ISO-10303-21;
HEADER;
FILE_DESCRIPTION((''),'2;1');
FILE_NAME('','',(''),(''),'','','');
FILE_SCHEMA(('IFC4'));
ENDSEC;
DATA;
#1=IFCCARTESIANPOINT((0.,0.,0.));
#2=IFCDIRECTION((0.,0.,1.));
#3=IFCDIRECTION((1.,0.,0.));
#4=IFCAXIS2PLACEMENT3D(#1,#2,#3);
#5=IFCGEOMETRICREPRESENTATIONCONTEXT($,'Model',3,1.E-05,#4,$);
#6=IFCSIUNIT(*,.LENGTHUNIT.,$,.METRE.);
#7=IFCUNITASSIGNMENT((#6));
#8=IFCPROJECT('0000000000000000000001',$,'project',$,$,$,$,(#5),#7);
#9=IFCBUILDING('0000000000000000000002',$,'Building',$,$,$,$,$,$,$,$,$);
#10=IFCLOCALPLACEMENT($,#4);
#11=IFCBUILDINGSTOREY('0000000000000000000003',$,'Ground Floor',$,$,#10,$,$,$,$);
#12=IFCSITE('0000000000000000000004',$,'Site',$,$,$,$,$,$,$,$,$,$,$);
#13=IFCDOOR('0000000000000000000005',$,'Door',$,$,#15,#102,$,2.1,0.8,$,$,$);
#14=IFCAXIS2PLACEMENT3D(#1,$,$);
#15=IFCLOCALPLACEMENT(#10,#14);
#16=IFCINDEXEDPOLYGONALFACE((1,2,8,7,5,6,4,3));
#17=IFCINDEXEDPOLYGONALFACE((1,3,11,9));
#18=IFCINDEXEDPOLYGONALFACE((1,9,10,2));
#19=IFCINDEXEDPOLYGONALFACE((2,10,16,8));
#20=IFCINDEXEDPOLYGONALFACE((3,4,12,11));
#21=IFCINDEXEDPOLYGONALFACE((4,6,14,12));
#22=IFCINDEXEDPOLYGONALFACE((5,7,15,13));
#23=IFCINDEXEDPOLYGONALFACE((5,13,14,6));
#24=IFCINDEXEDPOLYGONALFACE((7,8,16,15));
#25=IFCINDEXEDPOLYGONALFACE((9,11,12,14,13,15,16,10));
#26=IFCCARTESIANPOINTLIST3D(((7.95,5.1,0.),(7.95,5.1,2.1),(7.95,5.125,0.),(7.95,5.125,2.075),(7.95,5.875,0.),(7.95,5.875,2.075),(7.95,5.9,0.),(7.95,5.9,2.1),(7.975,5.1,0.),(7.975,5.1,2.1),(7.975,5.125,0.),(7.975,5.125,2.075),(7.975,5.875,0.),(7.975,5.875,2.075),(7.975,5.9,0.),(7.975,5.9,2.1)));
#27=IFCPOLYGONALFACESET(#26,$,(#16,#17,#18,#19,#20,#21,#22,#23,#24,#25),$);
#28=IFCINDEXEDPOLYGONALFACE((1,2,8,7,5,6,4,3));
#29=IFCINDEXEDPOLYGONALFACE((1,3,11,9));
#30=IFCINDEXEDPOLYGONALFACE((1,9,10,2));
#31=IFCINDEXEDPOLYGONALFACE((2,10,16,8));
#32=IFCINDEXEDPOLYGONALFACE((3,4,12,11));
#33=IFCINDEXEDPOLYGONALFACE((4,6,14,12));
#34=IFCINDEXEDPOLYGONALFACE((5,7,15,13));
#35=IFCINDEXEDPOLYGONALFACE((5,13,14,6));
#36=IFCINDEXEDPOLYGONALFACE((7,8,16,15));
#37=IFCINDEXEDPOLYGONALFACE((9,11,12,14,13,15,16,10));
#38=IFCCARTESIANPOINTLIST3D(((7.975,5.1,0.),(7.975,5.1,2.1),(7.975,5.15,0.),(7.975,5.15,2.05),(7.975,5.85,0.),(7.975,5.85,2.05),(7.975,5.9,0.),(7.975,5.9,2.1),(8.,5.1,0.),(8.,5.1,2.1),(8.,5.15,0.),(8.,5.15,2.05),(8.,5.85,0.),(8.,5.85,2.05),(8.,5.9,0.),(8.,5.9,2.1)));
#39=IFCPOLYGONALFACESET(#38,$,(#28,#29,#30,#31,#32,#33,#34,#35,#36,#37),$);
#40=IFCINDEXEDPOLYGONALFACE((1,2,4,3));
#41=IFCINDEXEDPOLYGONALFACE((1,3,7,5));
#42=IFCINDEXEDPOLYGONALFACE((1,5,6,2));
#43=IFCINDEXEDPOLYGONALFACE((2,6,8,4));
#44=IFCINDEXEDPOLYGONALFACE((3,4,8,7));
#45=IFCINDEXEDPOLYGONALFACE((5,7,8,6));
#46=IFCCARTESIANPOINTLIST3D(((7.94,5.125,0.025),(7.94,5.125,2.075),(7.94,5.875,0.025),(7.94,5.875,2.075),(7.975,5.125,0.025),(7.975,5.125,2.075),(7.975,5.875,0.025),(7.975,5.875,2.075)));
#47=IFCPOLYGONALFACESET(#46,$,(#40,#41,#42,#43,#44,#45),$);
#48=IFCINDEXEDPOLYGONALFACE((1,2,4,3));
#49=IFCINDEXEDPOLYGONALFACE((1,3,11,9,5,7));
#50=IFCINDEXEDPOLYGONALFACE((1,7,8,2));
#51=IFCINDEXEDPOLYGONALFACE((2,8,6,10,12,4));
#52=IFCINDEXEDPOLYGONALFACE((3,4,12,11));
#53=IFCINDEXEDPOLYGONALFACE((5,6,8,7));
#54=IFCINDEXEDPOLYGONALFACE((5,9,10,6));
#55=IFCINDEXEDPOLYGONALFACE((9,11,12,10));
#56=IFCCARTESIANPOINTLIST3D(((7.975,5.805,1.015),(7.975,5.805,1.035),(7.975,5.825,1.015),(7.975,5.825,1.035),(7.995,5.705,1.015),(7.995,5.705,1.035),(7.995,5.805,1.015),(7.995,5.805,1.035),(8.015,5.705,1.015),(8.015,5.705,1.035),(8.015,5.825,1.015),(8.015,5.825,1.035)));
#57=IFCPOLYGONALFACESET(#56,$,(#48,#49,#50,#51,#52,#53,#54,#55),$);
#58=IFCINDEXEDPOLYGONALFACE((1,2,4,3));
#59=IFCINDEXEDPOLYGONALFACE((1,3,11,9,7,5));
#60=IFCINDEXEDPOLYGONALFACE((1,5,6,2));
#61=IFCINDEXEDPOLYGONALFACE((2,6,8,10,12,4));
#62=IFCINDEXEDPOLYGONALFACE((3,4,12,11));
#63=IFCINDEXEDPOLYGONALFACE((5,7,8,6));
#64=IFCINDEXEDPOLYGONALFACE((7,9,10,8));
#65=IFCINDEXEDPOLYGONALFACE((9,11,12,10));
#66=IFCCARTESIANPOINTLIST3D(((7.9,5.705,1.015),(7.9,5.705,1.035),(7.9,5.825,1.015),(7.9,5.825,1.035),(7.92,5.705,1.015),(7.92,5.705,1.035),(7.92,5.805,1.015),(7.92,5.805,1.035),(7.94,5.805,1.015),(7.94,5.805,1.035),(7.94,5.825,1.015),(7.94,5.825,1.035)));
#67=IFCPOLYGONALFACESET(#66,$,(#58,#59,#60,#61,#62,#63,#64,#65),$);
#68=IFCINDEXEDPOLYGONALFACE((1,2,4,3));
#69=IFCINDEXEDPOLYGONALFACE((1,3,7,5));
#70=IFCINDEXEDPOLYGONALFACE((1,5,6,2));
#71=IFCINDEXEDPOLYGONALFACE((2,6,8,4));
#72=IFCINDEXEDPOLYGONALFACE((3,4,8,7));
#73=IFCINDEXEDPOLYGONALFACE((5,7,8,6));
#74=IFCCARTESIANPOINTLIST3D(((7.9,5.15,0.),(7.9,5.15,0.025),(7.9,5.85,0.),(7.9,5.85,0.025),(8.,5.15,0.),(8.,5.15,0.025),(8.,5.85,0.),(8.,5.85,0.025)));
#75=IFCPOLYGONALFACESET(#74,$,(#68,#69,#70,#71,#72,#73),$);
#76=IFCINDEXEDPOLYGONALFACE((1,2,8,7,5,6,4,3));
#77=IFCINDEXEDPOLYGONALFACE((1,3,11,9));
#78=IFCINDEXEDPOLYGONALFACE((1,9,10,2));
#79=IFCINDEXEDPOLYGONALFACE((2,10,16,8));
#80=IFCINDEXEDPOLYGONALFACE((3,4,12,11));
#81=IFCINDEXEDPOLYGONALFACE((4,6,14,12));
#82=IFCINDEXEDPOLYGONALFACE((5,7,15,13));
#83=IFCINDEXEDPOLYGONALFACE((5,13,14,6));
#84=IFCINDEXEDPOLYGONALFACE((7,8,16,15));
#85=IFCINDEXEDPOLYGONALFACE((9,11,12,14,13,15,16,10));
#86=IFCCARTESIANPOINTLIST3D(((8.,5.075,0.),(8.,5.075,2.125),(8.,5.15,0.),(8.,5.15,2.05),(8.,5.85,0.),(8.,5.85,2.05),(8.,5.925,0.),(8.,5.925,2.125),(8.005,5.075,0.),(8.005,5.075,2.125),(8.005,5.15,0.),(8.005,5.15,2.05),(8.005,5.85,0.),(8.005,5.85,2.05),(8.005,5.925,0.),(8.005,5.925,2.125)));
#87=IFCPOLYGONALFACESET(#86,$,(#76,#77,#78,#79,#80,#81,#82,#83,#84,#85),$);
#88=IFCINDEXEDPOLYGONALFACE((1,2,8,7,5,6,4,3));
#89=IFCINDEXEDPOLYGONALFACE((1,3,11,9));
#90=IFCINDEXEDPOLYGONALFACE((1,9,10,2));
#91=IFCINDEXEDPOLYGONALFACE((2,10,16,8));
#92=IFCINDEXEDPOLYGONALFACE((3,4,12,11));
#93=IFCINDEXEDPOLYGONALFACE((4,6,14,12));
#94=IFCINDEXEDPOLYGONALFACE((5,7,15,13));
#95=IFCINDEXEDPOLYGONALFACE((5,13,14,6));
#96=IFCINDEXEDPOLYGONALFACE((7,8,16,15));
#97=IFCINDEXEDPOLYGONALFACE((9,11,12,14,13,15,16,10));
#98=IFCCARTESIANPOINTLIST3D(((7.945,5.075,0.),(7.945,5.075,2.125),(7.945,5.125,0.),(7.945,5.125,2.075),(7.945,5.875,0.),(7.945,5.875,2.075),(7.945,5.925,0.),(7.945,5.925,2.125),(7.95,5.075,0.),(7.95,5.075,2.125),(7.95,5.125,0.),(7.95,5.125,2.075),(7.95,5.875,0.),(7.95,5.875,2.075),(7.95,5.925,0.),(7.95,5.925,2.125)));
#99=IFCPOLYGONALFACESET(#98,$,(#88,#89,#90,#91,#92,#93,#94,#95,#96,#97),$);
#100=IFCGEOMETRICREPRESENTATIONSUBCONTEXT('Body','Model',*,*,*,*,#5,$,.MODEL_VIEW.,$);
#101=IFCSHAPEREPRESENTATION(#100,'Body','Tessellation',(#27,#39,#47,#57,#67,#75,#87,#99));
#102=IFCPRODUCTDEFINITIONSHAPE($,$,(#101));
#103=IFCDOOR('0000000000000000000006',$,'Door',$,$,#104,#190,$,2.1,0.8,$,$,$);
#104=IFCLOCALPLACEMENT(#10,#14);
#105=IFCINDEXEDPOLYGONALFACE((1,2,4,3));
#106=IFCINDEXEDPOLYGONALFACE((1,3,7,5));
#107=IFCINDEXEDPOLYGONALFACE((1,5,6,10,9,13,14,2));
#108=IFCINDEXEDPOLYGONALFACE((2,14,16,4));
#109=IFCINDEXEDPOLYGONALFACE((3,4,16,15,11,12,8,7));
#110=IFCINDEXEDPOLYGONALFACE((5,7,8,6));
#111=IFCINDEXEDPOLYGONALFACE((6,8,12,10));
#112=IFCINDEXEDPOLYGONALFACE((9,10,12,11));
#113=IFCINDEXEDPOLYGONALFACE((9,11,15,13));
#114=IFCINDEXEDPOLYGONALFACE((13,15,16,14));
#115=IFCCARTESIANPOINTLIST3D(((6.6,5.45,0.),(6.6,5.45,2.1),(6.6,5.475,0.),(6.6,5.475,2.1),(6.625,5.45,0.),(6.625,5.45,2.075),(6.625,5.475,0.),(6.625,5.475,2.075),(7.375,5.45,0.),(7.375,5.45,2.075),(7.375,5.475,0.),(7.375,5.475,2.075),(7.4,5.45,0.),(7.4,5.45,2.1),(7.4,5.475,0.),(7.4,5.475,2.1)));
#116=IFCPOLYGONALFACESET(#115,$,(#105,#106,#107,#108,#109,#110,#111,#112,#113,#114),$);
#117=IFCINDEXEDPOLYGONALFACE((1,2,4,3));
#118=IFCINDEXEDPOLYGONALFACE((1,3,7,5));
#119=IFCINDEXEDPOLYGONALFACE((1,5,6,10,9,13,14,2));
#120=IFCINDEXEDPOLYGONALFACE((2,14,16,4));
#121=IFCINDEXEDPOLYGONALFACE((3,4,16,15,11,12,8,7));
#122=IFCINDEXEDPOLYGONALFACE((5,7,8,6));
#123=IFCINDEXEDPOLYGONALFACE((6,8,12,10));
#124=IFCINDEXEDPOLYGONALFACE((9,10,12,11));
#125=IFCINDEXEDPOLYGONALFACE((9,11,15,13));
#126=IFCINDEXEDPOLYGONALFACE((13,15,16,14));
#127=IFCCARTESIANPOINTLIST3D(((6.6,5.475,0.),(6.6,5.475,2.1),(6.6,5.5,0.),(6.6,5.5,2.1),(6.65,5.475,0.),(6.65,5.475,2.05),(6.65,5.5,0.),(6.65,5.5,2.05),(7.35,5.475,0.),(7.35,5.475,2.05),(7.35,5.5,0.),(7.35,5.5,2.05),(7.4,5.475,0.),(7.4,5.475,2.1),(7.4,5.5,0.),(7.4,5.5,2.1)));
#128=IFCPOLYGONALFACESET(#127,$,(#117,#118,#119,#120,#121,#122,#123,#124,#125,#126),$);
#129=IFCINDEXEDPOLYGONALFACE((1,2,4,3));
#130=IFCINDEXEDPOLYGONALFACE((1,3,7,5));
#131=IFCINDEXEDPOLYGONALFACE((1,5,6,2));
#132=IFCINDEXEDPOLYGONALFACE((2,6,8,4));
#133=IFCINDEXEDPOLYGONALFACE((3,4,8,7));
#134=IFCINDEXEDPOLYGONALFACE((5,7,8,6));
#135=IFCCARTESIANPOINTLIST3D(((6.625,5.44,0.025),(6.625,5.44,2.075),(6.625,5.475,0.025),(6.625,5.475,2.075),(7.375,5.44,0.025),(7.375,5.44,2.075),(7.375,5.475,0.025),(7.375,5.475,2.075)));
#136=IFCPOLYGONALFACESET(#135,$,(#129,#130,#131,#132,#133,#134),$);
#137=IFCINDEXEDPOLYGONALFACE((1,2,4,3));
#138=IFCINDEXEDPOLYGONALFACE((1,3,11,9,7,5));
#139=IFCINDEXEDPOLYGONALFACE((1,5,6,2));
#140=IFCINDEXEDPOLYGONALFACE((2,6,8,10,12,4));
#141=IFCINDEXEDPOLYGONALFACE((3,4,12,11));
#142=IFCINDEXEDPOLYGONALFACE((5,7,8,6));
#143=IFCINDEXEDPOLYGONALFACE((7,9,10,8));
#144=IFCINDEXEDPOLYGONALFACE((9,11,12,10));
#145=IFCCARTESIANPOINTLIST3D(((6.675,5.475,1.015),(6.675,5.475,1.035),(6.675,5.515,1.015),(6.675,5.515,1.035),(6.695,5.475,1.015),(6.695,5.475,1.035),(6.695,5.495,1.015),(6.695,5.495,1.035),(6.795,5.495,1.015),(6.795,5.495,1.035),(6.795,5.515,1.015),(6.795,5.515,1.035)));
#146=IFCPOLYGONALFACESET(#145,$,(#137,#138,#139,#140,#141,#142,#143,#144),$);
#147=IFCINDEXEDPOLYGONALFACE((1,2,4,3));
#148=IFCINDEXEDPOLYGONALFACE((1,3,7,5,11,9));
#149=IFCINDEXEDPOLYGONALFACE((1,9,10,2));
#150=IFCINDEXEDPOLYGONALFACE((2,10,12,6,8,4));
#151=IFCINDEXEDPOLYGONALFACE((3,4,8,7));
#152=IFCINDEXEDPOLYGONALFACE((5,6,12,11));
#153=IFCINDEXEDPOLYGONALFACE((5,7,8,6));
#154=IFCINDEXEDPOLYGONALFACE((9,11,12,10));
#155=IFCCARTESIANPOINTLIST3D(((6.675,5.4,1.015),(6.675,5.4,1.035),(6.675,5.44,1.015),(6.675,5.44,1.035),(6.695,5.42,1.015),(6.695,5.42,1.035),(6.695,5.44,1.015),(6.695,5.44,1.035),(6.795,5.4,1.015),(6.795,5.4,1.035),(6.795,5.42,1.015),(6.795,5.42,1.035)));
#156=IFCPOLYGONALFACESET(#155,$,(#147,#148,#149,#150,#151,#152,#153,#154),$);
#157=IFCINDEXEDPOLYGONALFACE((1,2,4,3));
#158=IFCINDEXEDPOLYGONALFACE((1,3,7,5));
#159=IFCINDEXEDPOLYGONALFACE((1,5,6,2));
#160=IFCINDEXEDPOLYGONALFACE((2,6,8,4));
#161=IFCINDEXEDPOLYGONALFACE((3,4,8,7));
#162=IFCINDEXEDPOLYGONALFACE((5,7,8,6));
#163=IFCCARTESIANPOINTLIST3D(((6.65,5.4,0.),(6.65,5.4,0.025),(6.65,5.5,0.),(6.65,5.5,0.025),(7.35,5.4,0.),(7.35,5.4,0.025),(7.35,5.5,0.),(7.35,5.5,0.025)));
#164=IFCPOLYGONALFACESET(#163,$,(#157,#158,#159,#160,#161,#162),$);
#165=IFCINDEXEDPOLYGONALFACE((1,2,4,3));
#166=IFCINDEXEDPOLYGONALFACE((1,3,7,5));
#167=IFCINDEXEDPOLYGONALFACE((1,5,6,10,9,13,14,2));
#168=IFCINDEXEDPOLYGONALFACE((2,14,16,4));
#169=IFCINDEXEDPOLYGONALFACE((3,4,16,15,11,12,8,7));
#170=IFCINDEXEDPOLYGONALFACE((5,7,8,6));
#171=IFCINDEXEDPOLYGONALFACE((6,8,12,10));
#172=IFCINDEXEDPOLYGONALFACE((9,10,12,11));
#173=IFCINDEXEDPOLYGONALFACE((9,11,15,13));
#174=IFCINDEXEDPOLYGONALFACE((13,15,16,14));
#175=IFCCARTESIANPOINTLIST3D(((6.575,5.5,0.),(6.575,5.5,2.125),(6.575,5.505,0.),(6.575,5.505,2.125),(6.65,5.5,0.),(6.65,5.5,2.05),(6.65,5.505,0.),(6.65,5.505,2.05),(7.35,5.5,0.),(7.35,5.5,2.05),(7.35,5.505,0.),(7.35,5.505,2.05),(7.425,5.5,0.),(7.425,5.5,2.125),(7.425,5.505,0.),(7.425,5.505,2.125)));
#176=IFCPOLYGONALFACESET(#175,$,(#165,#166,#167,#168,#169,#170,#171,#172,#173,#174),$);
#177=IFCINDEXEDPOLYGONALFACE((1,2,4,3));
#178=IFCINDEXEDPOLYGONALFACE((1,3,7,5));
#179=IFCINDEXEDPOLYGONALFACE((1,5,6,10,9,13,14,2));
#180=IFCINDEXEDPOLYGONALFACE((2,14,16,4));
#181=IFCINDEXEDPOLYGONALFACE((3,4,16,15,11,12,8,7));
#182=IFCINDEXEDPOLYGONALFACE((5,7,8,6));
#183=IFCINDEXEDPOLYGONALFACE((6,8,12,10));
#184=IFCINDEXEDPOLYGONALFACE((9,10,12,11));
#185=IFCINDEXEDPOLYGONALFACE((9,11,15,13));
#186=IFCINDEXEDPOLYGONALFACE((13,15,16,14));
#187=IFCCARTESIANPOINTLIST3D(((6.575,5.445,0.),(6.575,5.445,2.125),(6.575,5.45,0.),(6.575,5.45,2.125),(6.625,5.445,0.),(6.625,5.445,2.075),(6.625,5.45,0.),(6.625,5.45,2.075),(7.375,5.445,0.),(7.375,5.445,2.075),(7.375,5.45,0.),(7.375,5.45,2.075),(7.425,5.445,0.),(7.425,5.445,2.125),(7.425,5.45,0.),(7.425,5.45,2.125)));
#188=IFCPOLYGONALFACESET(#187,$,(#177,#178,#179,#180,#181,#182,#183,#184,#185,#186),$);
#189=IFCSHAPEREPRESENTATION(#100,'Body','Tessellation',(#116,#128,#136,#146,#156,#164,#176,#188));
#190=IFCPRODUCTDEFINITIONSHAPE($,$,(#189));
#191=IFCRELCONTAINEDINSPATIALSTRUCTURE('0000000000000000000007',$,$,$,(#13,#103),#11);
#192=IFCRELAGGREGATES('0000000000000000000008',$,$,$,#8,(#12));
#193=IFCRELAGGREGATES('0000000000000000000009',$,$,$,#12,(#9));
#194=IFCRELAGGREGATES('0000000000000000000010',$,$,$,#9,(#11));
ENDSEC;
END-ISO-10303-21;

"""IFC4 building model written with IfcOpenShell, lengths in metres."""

from ifc_helpers import new_model, si_unit, frame, origin_with_axes, place, context, subcontext, project, spatial, line, indexed_curve, outline, extrude, element, save


model = new_model("IFC4")

# Units and contexts
model_context = context("Model", 3, precision=1e-05, world=origin_with_axes())
body_context = subcontext(model_context, "Body", "Model", "MODEL_VIEW")
ifc_project = project(units=[si_unit("LENGTHUNIT", "METRE")], contexts=[model_context])

# Site, building, storey
site = spatial("IfcSite", under=ifc_project, Name="Site")
building = spatial("IfcBuilding", under=site, Name="Building")
storey_placement = place(None, origin_with_axes())
storey = spatial("IfcBuildingStorey", under=building, at=storey_placement, Name="Ground Floor")

# Doors
door_1_placement = place(storey_placement, frame((8.0, 5.1, 0.0), z_axis=(0.0, 0.0, 1.0), x_axis=(0.0, 1.0, 0.0)))
element("IfcDoor", 1, at=door_1_placement, inside=storey, Name="Door", OverallHeight=2.1, OverallWidth=0.8, context=body_context, shape_type="SweptSolid", body=[
    extrude(outline(indexed_curve([(0.0, 0.0), (0.0, 2.1), (0.8, 2.1), (0.8, 0.0), (0.775, 0.0), (0.775, 2.075), (0.025, 2.075), (0.025, 0.0)], segments=[line(1, 2, 3, 4, 5, 6, 7, 8, 1)])), frame((0.0, 0.025, 0.0), z_axis=(0.0, -1.0, 0.0), x_axis=(1.0, 0.0, 0.0)), (0.0, 0.0, -1.0), 0.025),
    extrude(outline(indexed_curve([(0.0, 0.0), (0.0, 2.1), (0.8, 2.1), (0.8, 0.0), (0.75, 0.0), (0.75, 2.05), (0.05, 2.05), (0.05, 0.0)], segments=[line(1, 2, 3, 4, 5, 6, 7, 8, 1)])), frame((0.0, 0.0, 0.0), z_axis=(0.0, -1.0, 0.0), x_axis=(1.0, 0.0, 0.0)), (0.0, 0.0, -1.0), 0.025),
    extrude(outline(indexed_curve([(0.0, 0.0), (0.75, 0.0), (0.75, 0.035), (0.0, 0.035)], segments=[line(1, 2, 3, 4, 1)])), frame((0.025, 0.025, 0.025), z_axis=(0.0, 0.0, 1.0), x_axis=(1.0, 0.0, 0.0)), (0.0, 0.0, 1.0), 2.05),
    extrude(outline(indexed_curve([(0.0, 0.0), (0.0, -0.04), (-0.12, -0.04), (-0.12, -0.02), (-0.02, -0.02), (-0.02, 0.0)], segments=[line(1, 2, 3, 4, 5, 6, 1)])), frame((0.725, 0.025, 1.015), z_axis=(0.0, 0.0, 1.0), x_axis=(1.0, 0.0, 0.0)), (0.0, 0.0, 1.0), 0.02),
    extrude(outline(indexed_curve([(0.0, 0.0), (0.0, 0.04), (-0.12, 0.04), (-0.12, 0.02), (-0.02, 0.02), (-0.02, 0.0)], segments=[line(1, 2, 3, 4, 5, 6, 1)])), frame((0.725, 0.06, 1.015), z_axis=(0.0, 0.0, 1.0), x_axis=(1.0, 0.0, 0.0)), (0.0, 0.0, 1.0), 0.02),
    extrude(outline(indexed_curve([(0.0, 0.0), (0.7, 0.0), (0.7, 0.1), (0.0, 0.1)], segments=[line(1, 2, 3, 4, 1)])), frame((0.05, 0.0, 0.0), z_axis=(0.0, 0.0, 1.0), x_axis=(1.0, 0.0, 0.0)), (0.0, 0.0, 1.0), 0.025),
    extrude(outline(indexed_curve([(0.0, 0.0), (0.0, 2.125), (0.85, 2.125), (0.85, 0.0), (0.775, 0.0), (0.775, 2.05), (0.075, 2.05), (0.075, 0.0)], segments=[line(1, 2, 3, 4, 5, 6, 7, 8, 1)])), frame((-0.025, -0.005, 0.0), z_axis=(0.0, -1.0, 0.0), x_axis=(1.0, 0.0, 0.0)), (0.0, 0.0, -1.0), 0.005),
    extrude(outline(indexed_curve([(0.0, 0.0), (0.0, 2.125), (0.85, 2.125), (0.85, 0.0), (0.8, 0.0), (0.8, 2.075), (0.05, 2.075), (0.05, 0.0)], segments=[line(1, 2, 3, 4, 5, 6, 7, 8, 1)])), frame((-0.025, 0.05, 0.0), z_axis=(0.0, -1.0, 0.0), x_axis=(1.0, 0.0, 0.0)), (0.0, 0.0, -1.0), 0.005),
])
door_2_placement = place(storey_placement, frame((7.4, 5.5, 0.0), z_axis=(0.0, 0.0, 1.0), x_axis=(-1.0, 0.0, 0.0)))
element("IfcDoor", 2, at=door_2_placement, inside=storey, Name="Door", OverallHeight=2.1, OverallWidth=0.8, context=body_context, shape_type="SweptSolid", body=[
    extrude(outline(indexed_curve([(0.0, 0.0), (0.0, 2.1), (0.8, 2.1), (0.8, 0.0), (0.775, 0.0), (0.775, 2.075), (0.025, 2.075), (0.025, 0.0)], segments=[line(1, 2, 3, 4, 5, 6, 7, 8, 1)])), frame((0.0, 0.025, 0.0), z_axis=(0.0, -1.0, 0.0), x_axis=(1.0, 0.0, 0.0)), (0.0, 0.0, -1.0), 0.025),
    extrude(outline(indexed_curve([(0.0, 0.0), (0.0, 2.1), (0.8, 2.1), (0.8, 0.0), (0.75, 0.0), (0.75, 2.05), (0.05, 2.05), (0.05, 0.0)], segments=[line(1, 2, 3, 4, 5, 6, 7, 8, 1)])), frame((0.0, 0.0, 0.0), z_axis=(0.0, -1.0, 0.0), x_axis=(1.0, 0.0, 0.0)), (0.0, 0.0, -1.0), 0.025),
    extrude(outline(indexed_curve([(0.0, 0.0), (0.75, 0.0), (0.75, 0.035), (0.0, 0.035)], segments=[line(1, 2, 3, 4, 1)])), frame((0.025, 0.025, 0.025), z_axis=(0.0, 0.0, 1.0), x_axis=(1.0, 0.0, 0.0)), (0.0, 0.0, 1.0), 2.05),
    extrude(outline(indexed_curve([(0.0, 0.0), (0.0, -0.04), (-0.12, -0.04), (-0.12, -0.02), (-0.02, -0.02), (-0.02, 0.0)], segments=[line(1, 2, 3, 4, 5, 6, 1)])), frame((0.725, 0.025, 1.015), z_axis=(0.0, 0.0, 1.0), x_axis=(1.0, 0.0, 0.0)), (0.0, 0.0, 1.0), 0.02),
    extrude(outline(indexed_curve([(0.0, 0.0), (0.0, 0.04), (-0.12, 0.04), (-0.12, 0.02), (-0.02, 0.02), (-0.02, 0.0)], segments=[line(1, 2, 3, 4, 5, 6, 1)])), frame((0.725, 0.06, 1.015), z_axis=(0.0, 0.0, 1.0), x_axis=(1.0, 0.0, 0.0)), (0.0, 0.0, 1.0), 0.02),
    extrude(outline(indexed_curve([(0.0, 0.0), (0.7, 0.0), (0.7, 0.1), (0.0, 0.1)], segments=[line(1, 2, 3, 4, 1)])), frame((0.05, 0.0, 0.0), z_axis=(0.0, 0.0, 1.0), x_axis=(1.0, 0.0, 0.0)), (0.0, 0.0, 1.0), 0.025),
    extrude(outline(indexed_curve([(0.0, 0.0), (0.0, 2.125), (0.85, 2.125), (0.85, 0.0), (0.775, 0.0), (0.775, 2.05), (0.075, 2.05), (0.075, 0.0)], segments=[line(1, 2, 3, 4, 5, 6, 7, 8, 1)])), frame((-0.025, -0.005, 0.0), z_axis=(0.0, -1.0, 0.0), x_axis=(1.0, 0.0, 0.0)), (0.0, 0.0, -1.0), 0.005),
    extrude(outline(indexed_curve([(0.0, 0.0), (0.0, 2.125), (0.85, 2.125), (0.85, 0.0), (0.8, 0.0), (0.8, 2.075), (0.05, 2.075), (0.05, 0.0)], segments=[line(1, 2, 3, 4, 5, 6, 7, 8, 1)])), frame((-0.025, 0.05, 0.0), z_axis=(0.0, -1.0, 0.0), x_axis=(1.0, 0.0, 0.0)), (0.0, 0.0, -1.0), 0.005),
])

save(model, "model.ifc")
